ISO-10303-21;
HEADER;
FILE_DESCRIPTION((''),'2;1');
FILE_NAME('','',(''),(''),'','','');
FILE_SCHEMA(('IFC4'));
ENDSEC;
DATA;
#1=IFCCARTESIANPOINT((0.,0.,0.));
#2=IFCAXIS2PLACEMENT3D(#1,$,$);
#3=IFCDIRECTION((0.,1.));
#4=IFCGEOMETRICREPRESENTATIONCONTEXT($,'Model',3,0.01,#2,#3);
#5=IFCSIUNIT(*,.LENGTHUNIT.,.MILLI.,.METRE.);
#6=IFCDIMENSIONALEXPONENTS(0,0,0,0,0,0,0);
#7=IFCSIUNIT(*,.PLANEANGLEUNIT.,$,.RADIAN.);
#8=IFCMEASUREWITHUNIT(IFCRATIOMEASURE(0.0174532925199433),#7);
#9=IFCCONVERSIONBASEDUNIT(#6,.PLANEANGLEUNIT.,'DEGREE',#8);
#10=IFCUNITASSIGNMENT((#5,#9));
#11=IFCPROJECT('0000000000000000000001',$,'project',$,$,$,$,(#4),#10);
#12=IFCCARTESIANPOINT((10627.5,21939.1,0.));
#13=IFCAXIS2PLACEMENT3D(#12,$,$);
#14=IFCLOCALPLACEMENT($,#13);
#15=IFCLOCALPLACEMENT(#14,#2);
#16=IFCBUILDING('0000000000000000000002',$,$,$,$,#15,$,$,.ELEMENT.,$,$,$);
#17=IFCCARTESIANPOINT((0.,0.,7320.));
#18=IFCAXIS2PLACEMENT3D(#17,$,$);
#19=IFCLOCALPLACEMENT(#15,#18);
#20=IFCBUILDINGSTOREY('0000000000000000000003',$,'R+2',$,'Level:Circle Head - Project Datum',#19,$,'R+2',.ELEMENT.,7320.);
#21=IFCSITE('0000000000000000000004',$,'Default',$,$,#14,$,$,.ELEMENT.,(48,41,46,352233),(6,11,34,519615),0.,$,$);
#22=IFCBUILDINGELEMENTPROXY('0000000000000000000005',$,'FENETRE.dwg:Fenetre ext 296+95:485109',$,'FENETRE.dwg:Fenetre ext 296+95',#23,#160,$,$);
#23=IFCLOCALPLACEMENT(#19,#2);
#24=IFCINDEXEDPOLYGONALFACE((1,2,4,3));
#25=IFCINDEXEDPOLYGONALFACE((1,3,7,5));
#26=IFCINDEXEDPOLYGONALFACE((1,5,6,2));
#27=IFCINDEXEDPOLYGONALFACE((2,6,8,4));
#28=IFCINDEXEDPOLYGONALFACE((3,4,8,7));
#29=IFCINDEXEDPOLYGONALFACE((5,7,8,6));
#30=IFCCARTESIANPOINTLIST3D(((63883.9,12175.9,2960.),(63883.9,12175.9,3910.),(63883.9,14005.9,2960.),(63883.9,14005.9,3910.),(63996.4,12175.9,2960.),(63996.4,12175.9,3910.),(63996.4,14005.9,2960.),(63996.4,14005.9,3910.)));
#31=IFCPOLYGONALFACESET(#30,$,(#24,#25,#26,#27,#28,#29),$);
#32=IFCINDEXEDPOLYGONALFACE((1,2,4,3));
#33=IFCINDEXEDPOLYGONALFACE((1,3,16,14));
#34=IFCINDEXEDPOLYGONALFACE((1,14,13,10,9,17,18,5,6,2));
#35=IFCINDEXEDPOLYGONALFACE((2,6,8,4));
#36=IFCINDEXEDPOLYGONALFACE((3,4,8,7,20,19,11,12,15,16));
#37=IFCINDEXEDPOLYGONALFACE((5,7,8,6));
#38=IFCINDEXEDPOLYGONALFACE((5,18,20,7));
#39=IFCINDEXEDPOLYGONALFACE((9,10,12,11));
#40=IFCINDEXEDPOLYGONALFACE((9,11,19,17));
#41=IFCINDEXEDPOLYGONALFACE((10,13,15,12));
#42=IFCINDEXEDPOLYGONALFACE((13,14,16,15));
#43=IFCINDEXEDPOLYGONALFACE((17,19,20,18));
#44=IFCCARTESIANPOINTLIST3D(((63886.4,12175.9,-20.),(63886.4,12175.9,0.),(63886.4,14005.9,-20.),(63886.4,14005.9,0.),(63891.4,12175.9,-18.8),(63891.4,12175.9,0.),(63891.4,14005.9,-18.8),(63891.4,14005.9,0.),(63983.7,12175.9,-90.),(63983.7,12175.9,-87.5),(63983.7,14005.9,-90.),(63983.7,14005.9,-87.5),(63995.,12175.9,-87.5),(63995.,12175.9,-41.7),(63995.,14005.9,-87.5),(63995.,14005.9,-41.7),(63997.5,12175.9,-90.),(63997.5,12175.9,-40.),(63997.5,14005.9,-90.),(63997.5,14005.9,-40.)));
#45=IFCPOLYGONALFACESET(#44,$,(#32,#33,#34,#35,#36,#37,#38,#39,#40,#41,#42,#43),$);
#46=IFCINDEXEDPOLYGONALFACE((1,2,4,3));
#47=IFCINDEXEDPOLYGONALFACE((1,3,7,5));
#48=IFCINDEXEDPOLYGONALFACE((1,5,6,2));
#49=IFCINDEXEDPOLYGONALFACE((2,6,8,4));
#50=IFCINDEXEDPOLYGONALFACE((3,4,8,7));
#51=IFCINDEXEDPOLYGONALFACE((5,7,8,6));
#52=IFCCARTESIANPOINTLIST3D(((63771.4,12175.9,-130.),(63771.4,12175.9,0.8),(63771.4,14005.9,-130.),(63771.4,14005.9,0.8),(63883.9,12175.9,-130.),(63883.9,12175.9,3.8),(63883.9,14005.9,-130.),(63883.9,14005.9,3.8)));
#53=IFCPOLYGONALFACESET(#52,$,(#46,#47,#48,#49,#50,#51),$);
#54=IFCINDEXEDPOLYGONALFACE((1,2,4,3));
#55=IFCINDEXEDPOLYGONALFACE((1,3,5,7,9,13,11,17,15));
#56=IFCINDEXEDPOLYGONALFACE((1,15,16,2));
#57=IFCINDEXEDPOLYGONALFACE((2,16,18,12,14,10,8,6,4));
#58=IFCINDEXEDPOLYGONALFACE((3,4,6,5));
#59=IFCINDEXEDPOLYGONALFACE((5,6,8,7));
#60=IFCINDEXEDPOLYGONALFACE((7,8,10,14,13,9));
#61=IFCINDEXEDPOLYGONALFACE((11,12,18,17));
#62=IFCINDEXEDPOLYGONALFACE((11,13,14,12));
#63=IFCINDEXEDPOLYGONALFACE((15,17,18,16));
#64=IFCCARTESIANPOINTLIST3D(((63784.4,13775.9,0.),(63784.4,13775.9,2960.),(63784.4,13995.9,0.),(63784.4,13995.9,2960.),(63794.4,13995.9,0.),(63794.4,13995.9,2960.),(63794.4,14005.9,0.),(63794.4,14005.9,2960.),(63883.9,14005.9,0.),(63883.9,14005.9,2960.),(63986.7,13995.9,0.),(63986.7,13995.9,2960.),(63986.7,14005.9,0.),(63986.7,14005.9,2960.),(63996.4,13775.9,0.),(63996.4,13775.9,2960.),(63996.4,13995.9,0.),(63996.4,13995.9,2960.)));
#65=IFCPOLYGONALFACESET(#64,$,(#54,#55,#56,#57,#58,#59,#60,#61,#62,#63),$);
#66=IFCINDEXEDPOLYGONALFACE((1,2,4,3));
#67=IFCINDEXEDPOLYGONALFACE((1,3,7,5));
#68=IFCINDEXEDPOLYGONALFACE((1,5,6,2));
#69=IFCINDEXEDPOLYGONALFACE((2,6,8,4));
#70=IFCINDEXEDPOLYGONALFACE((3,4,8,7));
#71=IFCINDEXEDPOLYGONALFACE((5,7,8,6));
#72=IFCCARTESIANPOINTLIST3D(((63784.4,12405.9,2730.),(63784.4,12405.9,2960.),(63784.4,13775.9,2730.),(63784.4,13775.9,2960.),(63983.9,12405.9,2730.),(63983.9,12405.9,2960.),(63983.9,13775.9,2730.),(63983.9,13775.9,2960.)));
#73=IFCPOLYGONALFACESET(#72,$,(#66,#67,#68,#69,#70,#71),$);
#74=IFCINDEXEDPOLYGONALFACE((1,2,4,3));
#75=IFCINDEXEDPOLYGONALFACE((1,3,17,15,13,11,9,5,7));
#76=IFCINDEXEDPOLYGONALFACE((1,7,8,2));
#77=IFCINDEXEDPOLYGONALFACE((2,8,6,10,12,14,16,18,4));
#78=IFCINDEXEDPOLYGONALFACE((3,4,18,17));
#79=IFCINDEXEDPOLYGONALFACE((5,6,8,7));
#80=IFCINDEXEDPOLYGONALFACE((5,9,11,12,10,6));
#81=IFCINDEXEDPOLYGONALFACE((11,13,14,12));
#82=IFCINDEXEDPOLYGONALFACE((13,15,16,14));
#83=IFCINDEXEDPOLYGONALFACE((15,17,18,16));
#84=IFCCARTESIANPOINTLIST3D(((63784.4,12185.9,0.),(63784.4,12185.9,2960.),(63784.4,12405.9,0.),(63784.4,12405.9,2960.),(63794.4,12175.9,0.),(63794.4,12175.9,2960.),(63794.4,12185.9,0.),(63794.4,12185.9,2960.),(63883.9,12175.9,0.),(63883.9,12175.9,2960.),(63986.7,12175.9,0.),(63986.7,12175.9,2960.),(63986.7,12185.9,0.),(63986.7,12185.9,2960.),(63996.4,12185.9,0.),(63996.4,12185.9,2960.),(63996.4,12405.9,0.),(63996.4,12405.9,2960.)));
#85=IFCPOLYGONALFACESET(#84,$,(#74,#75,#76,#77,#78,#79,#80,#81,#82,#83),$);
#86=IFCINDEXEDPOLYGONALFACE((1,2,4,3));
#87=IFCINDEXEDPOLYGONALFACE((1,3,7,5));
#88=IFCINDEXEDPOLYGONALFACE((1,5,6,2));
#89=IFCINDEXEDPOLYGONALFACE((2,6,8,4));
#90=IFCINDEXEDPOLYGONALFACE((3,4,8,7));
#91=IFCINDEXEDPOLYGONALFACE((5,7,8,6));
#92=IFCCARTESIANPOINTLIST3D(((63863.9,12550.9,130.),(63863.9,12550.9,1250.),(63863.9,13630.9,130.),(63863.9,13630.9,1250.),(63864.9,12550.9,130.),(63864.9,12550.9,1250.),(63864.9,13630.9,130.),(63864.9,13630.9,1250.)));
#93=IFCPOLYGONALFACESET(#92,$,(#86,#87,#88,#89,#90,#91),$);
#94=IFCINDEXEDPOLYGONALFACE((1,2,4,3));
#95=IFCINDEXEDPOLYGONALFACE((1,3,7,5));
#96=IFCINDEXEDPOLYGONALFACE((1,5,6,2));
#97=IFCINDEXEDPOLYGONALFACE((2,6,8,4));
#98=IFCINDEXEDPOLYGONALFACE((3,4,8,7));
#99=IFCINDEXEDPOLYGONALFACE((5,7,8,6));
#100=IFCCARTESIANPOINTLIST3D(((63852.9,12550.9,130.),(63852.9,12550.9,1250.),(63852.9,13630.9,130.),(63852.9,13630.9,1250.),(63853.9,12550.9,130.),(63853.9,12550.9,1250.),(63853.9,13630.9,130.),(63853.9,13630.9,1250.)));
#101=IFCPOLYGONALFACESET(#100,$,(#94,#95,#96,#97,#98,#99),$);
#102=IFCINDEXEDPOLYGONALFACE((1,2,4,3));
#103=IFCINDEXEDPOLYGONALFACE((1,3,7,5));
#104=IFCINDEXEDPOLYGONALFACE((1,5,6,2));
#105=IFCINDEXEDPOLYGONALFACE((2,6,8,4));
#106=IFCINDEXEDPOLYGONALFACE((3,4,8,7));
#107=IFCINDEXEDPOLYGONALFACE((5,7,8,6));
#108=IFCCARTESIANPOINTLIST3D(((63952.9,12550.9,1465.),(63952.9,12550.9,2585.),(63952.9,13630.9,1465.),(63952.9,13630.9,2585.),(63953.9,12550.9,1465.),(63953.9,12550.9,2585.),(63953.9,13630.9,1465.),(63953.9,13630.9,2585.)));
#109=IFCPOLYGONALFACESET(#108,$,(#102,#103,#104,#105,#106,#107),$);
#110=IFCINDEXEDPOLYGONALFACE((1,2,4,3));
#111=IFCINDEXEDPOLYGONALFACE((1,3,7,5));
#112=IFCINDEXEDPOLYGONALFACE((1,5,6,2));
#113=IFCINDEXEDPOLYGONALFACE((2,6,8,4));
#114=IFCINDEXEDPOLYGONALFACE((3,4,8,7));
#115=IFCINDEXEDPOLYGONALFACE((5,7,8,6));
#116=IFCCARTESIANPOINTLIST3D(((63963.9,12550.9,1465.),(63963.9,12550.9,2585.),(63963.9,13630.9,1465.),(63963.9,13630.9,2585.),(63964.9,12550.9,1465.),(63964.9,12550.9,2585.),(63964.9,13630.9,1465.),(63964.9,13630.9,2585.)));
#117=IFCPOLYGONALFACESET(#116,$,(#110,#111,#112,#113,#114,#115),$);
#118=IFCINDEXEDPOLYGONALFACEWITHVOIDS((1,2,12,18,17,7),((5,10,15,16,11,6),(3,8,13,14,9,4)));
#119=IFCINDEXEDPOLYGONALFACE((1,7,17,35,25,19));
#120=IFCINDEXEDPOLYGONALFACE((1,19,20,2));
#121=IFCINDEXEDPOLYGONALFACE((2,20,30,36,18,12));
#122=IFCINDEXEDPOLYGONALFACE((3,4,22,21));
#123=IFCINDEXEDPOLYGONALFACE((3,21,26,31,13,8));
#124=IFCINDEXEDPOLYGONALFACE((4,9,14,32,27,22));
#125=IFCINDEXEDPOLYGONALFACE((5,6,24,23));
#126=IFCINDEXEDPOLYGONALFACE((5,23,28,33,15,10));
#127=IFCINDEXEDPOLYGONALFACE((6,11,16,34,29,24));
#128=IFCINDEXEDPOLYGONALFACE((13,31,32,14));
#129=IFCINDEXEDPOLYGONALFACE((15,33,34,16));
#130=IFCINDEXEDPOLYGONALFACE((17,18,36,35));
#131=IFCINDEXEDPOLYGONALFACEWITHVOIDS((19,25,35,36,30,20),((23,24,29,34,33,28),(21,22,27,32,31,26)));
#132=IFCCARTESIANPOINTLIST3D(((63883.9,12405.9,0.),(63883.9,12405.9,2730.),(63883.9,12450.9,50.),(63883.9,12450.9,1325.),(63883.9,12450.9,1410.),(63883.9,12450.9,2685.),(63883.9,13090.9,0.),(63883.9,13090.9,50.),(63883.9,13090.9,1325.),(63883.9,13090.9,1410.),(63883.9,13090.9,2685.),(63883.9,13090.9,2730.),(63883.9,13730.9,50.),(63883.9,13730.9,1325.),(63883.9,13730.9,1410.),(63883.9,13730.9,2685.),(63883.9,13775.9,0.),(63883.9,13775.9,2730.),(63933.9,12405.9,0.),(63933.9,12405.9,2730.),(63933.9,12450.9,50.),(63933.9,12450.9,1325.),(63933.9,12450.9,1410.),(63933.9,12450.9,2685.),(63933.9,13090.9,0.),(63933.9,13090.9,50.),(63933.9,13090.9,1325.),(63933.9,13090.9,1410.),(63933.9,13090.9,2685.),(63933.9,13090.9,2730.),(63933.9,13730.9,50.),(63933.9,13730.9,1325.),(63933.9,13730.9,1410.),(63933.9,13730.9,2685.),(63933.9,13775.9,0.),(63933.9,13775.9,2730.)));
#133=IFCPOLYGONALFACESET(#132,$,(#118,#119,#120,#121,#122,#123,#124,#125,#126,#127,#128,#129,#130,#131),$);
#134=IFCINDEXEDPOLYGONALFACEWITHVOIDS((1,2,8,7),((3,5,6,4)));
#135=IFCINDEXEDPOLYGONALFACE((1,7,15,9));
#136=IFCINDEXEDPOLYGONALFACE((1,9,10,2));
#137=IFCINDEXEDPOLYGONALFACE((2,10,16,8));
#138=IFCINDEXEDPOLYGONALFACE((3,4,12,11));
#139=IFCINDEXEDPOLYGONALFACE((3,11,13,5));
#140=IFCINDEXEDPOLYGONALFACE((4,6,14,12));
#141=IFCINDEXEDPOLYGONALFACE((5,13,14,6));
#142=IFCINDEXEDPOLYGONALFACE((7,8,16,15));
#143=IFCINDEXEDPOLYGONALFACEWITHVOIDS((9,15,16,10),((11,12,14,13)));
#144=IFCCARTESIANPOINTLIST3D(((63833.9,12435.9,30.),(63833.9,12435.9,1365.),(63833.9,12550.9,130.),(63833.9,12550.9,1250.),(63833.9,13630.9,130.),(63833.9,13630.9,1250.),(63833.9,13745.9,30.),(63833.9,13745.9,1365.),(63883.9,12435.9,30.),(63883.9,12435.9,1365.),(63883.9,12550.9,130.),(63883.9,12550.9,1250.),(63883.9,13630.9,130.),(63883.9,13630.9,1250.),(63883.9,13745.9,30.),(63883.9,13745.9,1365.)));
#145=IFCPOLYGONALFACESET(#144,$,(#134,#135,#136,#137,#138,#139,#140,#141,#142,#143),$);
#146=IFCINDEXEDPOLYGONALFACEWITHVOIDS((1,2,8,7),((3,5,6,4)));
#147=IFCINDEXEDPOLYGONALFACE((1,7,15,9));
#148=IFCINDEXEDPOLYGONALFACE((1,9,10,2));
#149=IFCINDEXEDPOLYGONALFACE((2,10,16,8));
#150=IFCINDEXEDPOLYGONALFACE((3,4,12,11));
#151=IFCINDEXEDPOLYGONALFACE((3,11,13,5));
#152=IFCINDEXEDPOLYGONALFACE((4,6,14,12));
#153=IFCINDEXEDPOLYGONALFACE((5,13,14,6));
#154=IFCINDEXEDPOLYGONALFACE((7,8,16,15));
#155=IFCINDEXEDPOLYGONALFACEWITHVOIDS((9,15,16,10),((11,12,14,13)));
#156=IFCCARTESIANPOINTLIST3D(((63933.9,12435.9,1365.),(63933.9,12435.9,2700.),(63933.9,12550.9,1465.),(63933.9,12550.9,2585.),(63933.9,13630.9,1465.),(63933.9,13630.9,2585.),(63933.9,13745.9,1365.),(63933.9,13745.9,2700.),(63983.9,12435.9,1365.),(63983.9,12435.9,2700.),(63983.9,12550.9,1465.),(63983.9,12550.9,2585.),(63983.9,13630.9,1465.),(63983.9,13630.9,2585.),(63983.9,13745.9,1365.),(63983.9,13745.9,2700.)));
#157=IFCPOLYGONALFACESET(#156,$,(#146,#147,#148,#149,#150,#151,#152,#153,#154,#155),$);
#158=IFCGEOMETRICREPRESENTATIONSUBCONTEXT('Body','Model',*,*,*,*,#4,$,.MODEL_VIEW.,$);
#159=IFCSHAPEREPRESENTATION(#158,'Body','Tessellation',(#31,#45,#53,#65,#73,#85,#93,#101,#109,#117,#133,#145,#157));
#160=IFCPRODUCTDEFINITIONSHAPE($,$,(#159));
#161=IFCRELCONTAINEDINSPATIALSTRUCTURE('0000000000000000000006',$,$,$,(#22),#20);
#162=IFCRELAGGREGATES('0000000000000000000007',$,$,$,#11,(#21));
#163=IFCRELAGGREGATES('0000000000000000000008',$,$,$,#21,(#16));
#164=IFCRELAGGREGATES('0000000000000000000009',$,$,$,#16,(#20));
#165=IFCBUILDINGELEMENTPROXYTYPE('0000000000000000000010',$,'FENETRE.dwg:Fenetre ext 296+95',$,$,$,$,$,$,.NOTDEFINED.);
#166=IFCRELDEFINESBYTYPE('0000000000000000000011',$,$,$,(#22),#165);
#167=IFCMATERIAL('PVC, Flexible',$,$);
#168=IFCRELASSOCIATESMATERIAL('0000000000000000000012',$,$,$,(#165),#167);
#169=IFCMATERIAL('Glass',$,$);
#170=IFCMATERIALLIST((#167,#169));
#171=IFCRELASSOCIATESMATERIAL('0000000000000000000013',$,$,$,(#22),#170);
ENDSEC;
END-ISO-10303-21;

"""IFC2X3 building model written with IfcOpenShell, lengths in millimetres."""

from ifc_helpers import new_model, entity, si_unit, converted_unit, direction, frame, frame_2d, origin, origin_2d_with_axis, place, context, subcontext, project, spatial, polyline, rectangle, outline, extrude, source, transform, mapped, material, material_list, type_object, type_shapes, element, save


model = new_model("IFC2X3")

# Units and contexts
model_context = context("Model", 3, precision=0.01, world=origin(), true_north=direction((0.0, 1.0)))
body_context = subcontext(model_context, "Body", "Model", "MODEL_VIEW")
ifc_project = project(units=[si_unit("LENGTHUNIT", "METRE", prefix="MILLI"), converted_unit("PLANEANGLEUNIT", "DEGREE", entity("IfcRatioMeasure", 0.0174532925199433), si_unit("PLANEANGLEUNIT", "RADIAN"), dimensions=[0, 0, 0, 0, 0, 0, 0])], contexts=[model_context])

# Site, building, storey
site_placement = place(None, frame((10627.5, 21939.1, 0.0)))
site = spatial("IfcSite", under=ifc_project, at=site_placement, Name="Default", CompositionType="ELEMENT", RefLatitude=(48, 41, 46, 352233), RefLongitude=(6, 11, 34, 519615), RefElevation=0.0)
building_placement = place(site_placement, origin())
building = spatial("IfcBuilding", under=site, at=building_placement, CompositionType="ELEMENT")
storey_placement = place(building_placement, frame((0.0, 0.0, 7320.0)))
storey = spatial("IfcBuildingStorey", under=building, at=storey_placement, Name="R+2", ObjectType="Level:Circle Head - Project Datum", LongName="R+2", CompositionType="ELEMENT", Elevation=7320.0)

# Building element proxy
ifc_material_1 = material(Name="PVC, Flexible")
ifc_material_2 = material(Name="Glass")
building_element_proxy_type_1 = type_object("IfcBuildingElementProxyType", Name="FENETRE.dwg:Fenetre ext 296+95", PredefinedType="NOTDEFINED", material=ifc_material_1)
shared_shape_1 = source(origin(), body_context, "Body", "SweptSolid", [
    extrude(rectangle(XDim=112.5, YDim=1830.0, at=origin_2d_with_axis()), frame((-10.4, -56.3, 2960.0), z_axis=(0.0, 0.0, 1.0), x_axis=(0.0, 1.0, 0.0)), (0.0, 0.0, 1.0), 950.0),
    extrude(outline(polyline([(27.5, -64.4), (47.5, -64.4), (47.5, -59.4), (28.8, -59.4), (7.5, 46.7), (-42.5, 46.7), (-42.5, 32.9), (-40.0, 32.9), (-40.0, 44.2), (5.8, 44.2), (27.5, -64.4)])), frame((-925.4, -66.9, -47.5), z_axis=(1.0, 0.0, 0.0), x_axis=(0.0, 0.0, 1.0)), (0.0, 0.0, 1.0), 1830.0),
    extrude(outline(polyline([(-54.5, -66.1), (58.0, -66.1), (54.5, 67.6), (-58.0, 64.6), (-54.5, -66.1)])), frame((-925.4, 56.3, -63.8), z_axis=(1.0, 0.0, 0.0), x_axis=(0.0, -0.999645, 0.02665)), (0.0, 0.0, 1.0), 1830.0),
    extrude(outline(polyline([(-97.0, -55.6), (5.9, -55.6), (95.4, -55.6), (95.4, -45.6), (105.4, -45.6), (105.4, 174.4), (-106.6, 174.4), (-106.6, -45.6), (-97.0, -45.6), (-97.0, -55.6)])), frame((849.0, -5.9, 0.0), z_axis=(0.0, 0.0, 1.0), x_axis=(0.0, 1.0, 0.0)), (0.0, 0.0, 1.0), 2960.0),
    extrude(rectangle(XDim=1370.0, YDim=199.5, at=origin_2d_with_axis()), frame((-10.4, -0.3, 2730.0), z_axis=(0.0, 0.0, 1.0), x_axis=(-1.0, 0.0, 0.0)), (0.0, 0.0, 1.0), 230.0),
    extrude(outline(polyline([(-55.6, 97.0), (-55.6, -5.9), (-55.6, -95.4), (-45.6, -95.4), (-45.6, -105.4), (174.4, -105.4), (174.4, 106.6), (-45.6, 106.6), (-45.6, 97.0), (-55.6, 97.0)])), frame((-869.9, -5.9, 0.0), z_axis=(0.0, 0.0, -1.0), x_axis=(1.0, 0.0, 0.0)), (0.0, 0.0, -1.0), 2960.0),
    extrude(rectangle(XDim=1080.0, YDim=1.0, at=origin_2d_with_axis()), frame((-10.4, 19.5, 130.0), z_axis=(0.0, 0.0, 1.0), x_axis=(-1.0, 0.0, 0.0)), (0.0, 0.0, 1.0), 1120.0),
    extrude(rectangle(XDim=1080.0, YDim=1.0, at=origin_2d_with_axis()), frame((-10.4, 30.5, 130.0), z_axis=(0.0, 0.0, 1.0), x_axis=(-1.0, 0.0, 0.0)), (0.0, 0.0, 1.0), 1120.0),
    extrude(rectangle(XDim=1080.0, YDim=1.0, at=frame_2d((0.0, 0.0), x_axis=(1.0, 0.0))), frame((-10.4, -69.5, 1465.0), z_axis=(0.0, 0.0, 1.0), x_axis=(-1.0, 0.0, 0.0)), (0.0, 0.0, 1.0), 1120.0),
    extrude(rectangle(XDim=1080.0, YDim=1.0, at=frame_2d((0.0, 0.0), x_axis=(1.0, 0.0))), frame((-10.4, -80.5, 1465.0), z_axis=(0.0, 0.0, 1.0), x_axis=(-1.0, 0.0, 0.0)), (0.0, 0.0, 1.0), 1120.0),
    extrude(outline(polyline([(-685.0, -1365.0), (0.0, -1365.0), (685.0, -1365.0), (685.0, 1365.0), (0.0, 1365.0), (-685.0, 1365.0), (-685.0, -1365.0)]), holes=[polyline([(-640.0, -1320.0), (-640.0, -45.0), (0.0, -45.0), (640.0, -45.0), (640.0, -1320.0), (0.0, -1320.0), (-640.0, -1320.0)]), polyline([(-640.0, 40.0), (-640.0, 1315.0), (0.0, 1315.0), (640.0, 1315.0), (640.0, 40.0), (0.0, 40.0), (-640.0, 40.0)])]), frame((-10.4, -50.0, 1365.0), z_axis=(0.0, 1.0, 0.0), x_axis=(1.0, 0.0, 0.0)), (0.0, 0.0, 1.0), 50.0),
    extrude(outline(polyline([(-655.0, -667.5), (655.0, -667.5), (655.0, 667.5), (-655.0, 667.5), (-655.0, -667.5)]), holes=[polyline([(-540.0, 552.5), (540.0, 552.5), (540.0, -567.5), (-540.0, -567.5), (-540.0, 552.5)])]), frame((-10.4, 0.0, 697.5), z_axis=(0.0, 1.0, 0.0), x_axis=(-1.0, 0.0, 0.0)), (0.0, 0.0, 1.0), 50.0),
    extrude(outline(polyline([(-655.0, -667.5), (655.0, -667.5), (655.0, 667.5), (-655.0, 667.5), (-655.0, -667.5)]), holes=[polyline([(-540.0, 552.5), (540.0, 552.5), (540.0, -567.5), (-540.0, -567.5), (-540.0, 552.5)])]), frame((-10.4, -100.0, 2032.5), z_axis=(0.0, 1.0, 0.0), x_axis=(-1.0, 0.0, 0.0)), (0.0, 0.0, 1.0), 50.0),
])
type_shapes(building_element_proxy_type_1, [shared_shape_1])
ifc_material_list_1 = material_list([ifc_material_1, ifc_material_2])
proxy_1_placement = place(storey_placement, frame((63883.9, 13101.3, 0.0), z_axis=(0.0, 0.0, 1.0), x_axis=(0.0, 1.0, 0.0)))
element("IfcBuildingElementProxy", 1, at=proxy_1_placement, inside=storey, type_object=building_element_proxy_type_1, material=ifc_material_list_1, Name="FENETRE.dwg:Fenetre ext 296+95:485109", ObjectType="FENETRE.dwg:Fenetre ext 296+95", context=body_context, shape_type="MappedRepresentation", body=[
    mapped(shared_shape_1, transform((0.0, 0.0, 0.0), scale=1.0)),
])

save(model, "model.ifc")
